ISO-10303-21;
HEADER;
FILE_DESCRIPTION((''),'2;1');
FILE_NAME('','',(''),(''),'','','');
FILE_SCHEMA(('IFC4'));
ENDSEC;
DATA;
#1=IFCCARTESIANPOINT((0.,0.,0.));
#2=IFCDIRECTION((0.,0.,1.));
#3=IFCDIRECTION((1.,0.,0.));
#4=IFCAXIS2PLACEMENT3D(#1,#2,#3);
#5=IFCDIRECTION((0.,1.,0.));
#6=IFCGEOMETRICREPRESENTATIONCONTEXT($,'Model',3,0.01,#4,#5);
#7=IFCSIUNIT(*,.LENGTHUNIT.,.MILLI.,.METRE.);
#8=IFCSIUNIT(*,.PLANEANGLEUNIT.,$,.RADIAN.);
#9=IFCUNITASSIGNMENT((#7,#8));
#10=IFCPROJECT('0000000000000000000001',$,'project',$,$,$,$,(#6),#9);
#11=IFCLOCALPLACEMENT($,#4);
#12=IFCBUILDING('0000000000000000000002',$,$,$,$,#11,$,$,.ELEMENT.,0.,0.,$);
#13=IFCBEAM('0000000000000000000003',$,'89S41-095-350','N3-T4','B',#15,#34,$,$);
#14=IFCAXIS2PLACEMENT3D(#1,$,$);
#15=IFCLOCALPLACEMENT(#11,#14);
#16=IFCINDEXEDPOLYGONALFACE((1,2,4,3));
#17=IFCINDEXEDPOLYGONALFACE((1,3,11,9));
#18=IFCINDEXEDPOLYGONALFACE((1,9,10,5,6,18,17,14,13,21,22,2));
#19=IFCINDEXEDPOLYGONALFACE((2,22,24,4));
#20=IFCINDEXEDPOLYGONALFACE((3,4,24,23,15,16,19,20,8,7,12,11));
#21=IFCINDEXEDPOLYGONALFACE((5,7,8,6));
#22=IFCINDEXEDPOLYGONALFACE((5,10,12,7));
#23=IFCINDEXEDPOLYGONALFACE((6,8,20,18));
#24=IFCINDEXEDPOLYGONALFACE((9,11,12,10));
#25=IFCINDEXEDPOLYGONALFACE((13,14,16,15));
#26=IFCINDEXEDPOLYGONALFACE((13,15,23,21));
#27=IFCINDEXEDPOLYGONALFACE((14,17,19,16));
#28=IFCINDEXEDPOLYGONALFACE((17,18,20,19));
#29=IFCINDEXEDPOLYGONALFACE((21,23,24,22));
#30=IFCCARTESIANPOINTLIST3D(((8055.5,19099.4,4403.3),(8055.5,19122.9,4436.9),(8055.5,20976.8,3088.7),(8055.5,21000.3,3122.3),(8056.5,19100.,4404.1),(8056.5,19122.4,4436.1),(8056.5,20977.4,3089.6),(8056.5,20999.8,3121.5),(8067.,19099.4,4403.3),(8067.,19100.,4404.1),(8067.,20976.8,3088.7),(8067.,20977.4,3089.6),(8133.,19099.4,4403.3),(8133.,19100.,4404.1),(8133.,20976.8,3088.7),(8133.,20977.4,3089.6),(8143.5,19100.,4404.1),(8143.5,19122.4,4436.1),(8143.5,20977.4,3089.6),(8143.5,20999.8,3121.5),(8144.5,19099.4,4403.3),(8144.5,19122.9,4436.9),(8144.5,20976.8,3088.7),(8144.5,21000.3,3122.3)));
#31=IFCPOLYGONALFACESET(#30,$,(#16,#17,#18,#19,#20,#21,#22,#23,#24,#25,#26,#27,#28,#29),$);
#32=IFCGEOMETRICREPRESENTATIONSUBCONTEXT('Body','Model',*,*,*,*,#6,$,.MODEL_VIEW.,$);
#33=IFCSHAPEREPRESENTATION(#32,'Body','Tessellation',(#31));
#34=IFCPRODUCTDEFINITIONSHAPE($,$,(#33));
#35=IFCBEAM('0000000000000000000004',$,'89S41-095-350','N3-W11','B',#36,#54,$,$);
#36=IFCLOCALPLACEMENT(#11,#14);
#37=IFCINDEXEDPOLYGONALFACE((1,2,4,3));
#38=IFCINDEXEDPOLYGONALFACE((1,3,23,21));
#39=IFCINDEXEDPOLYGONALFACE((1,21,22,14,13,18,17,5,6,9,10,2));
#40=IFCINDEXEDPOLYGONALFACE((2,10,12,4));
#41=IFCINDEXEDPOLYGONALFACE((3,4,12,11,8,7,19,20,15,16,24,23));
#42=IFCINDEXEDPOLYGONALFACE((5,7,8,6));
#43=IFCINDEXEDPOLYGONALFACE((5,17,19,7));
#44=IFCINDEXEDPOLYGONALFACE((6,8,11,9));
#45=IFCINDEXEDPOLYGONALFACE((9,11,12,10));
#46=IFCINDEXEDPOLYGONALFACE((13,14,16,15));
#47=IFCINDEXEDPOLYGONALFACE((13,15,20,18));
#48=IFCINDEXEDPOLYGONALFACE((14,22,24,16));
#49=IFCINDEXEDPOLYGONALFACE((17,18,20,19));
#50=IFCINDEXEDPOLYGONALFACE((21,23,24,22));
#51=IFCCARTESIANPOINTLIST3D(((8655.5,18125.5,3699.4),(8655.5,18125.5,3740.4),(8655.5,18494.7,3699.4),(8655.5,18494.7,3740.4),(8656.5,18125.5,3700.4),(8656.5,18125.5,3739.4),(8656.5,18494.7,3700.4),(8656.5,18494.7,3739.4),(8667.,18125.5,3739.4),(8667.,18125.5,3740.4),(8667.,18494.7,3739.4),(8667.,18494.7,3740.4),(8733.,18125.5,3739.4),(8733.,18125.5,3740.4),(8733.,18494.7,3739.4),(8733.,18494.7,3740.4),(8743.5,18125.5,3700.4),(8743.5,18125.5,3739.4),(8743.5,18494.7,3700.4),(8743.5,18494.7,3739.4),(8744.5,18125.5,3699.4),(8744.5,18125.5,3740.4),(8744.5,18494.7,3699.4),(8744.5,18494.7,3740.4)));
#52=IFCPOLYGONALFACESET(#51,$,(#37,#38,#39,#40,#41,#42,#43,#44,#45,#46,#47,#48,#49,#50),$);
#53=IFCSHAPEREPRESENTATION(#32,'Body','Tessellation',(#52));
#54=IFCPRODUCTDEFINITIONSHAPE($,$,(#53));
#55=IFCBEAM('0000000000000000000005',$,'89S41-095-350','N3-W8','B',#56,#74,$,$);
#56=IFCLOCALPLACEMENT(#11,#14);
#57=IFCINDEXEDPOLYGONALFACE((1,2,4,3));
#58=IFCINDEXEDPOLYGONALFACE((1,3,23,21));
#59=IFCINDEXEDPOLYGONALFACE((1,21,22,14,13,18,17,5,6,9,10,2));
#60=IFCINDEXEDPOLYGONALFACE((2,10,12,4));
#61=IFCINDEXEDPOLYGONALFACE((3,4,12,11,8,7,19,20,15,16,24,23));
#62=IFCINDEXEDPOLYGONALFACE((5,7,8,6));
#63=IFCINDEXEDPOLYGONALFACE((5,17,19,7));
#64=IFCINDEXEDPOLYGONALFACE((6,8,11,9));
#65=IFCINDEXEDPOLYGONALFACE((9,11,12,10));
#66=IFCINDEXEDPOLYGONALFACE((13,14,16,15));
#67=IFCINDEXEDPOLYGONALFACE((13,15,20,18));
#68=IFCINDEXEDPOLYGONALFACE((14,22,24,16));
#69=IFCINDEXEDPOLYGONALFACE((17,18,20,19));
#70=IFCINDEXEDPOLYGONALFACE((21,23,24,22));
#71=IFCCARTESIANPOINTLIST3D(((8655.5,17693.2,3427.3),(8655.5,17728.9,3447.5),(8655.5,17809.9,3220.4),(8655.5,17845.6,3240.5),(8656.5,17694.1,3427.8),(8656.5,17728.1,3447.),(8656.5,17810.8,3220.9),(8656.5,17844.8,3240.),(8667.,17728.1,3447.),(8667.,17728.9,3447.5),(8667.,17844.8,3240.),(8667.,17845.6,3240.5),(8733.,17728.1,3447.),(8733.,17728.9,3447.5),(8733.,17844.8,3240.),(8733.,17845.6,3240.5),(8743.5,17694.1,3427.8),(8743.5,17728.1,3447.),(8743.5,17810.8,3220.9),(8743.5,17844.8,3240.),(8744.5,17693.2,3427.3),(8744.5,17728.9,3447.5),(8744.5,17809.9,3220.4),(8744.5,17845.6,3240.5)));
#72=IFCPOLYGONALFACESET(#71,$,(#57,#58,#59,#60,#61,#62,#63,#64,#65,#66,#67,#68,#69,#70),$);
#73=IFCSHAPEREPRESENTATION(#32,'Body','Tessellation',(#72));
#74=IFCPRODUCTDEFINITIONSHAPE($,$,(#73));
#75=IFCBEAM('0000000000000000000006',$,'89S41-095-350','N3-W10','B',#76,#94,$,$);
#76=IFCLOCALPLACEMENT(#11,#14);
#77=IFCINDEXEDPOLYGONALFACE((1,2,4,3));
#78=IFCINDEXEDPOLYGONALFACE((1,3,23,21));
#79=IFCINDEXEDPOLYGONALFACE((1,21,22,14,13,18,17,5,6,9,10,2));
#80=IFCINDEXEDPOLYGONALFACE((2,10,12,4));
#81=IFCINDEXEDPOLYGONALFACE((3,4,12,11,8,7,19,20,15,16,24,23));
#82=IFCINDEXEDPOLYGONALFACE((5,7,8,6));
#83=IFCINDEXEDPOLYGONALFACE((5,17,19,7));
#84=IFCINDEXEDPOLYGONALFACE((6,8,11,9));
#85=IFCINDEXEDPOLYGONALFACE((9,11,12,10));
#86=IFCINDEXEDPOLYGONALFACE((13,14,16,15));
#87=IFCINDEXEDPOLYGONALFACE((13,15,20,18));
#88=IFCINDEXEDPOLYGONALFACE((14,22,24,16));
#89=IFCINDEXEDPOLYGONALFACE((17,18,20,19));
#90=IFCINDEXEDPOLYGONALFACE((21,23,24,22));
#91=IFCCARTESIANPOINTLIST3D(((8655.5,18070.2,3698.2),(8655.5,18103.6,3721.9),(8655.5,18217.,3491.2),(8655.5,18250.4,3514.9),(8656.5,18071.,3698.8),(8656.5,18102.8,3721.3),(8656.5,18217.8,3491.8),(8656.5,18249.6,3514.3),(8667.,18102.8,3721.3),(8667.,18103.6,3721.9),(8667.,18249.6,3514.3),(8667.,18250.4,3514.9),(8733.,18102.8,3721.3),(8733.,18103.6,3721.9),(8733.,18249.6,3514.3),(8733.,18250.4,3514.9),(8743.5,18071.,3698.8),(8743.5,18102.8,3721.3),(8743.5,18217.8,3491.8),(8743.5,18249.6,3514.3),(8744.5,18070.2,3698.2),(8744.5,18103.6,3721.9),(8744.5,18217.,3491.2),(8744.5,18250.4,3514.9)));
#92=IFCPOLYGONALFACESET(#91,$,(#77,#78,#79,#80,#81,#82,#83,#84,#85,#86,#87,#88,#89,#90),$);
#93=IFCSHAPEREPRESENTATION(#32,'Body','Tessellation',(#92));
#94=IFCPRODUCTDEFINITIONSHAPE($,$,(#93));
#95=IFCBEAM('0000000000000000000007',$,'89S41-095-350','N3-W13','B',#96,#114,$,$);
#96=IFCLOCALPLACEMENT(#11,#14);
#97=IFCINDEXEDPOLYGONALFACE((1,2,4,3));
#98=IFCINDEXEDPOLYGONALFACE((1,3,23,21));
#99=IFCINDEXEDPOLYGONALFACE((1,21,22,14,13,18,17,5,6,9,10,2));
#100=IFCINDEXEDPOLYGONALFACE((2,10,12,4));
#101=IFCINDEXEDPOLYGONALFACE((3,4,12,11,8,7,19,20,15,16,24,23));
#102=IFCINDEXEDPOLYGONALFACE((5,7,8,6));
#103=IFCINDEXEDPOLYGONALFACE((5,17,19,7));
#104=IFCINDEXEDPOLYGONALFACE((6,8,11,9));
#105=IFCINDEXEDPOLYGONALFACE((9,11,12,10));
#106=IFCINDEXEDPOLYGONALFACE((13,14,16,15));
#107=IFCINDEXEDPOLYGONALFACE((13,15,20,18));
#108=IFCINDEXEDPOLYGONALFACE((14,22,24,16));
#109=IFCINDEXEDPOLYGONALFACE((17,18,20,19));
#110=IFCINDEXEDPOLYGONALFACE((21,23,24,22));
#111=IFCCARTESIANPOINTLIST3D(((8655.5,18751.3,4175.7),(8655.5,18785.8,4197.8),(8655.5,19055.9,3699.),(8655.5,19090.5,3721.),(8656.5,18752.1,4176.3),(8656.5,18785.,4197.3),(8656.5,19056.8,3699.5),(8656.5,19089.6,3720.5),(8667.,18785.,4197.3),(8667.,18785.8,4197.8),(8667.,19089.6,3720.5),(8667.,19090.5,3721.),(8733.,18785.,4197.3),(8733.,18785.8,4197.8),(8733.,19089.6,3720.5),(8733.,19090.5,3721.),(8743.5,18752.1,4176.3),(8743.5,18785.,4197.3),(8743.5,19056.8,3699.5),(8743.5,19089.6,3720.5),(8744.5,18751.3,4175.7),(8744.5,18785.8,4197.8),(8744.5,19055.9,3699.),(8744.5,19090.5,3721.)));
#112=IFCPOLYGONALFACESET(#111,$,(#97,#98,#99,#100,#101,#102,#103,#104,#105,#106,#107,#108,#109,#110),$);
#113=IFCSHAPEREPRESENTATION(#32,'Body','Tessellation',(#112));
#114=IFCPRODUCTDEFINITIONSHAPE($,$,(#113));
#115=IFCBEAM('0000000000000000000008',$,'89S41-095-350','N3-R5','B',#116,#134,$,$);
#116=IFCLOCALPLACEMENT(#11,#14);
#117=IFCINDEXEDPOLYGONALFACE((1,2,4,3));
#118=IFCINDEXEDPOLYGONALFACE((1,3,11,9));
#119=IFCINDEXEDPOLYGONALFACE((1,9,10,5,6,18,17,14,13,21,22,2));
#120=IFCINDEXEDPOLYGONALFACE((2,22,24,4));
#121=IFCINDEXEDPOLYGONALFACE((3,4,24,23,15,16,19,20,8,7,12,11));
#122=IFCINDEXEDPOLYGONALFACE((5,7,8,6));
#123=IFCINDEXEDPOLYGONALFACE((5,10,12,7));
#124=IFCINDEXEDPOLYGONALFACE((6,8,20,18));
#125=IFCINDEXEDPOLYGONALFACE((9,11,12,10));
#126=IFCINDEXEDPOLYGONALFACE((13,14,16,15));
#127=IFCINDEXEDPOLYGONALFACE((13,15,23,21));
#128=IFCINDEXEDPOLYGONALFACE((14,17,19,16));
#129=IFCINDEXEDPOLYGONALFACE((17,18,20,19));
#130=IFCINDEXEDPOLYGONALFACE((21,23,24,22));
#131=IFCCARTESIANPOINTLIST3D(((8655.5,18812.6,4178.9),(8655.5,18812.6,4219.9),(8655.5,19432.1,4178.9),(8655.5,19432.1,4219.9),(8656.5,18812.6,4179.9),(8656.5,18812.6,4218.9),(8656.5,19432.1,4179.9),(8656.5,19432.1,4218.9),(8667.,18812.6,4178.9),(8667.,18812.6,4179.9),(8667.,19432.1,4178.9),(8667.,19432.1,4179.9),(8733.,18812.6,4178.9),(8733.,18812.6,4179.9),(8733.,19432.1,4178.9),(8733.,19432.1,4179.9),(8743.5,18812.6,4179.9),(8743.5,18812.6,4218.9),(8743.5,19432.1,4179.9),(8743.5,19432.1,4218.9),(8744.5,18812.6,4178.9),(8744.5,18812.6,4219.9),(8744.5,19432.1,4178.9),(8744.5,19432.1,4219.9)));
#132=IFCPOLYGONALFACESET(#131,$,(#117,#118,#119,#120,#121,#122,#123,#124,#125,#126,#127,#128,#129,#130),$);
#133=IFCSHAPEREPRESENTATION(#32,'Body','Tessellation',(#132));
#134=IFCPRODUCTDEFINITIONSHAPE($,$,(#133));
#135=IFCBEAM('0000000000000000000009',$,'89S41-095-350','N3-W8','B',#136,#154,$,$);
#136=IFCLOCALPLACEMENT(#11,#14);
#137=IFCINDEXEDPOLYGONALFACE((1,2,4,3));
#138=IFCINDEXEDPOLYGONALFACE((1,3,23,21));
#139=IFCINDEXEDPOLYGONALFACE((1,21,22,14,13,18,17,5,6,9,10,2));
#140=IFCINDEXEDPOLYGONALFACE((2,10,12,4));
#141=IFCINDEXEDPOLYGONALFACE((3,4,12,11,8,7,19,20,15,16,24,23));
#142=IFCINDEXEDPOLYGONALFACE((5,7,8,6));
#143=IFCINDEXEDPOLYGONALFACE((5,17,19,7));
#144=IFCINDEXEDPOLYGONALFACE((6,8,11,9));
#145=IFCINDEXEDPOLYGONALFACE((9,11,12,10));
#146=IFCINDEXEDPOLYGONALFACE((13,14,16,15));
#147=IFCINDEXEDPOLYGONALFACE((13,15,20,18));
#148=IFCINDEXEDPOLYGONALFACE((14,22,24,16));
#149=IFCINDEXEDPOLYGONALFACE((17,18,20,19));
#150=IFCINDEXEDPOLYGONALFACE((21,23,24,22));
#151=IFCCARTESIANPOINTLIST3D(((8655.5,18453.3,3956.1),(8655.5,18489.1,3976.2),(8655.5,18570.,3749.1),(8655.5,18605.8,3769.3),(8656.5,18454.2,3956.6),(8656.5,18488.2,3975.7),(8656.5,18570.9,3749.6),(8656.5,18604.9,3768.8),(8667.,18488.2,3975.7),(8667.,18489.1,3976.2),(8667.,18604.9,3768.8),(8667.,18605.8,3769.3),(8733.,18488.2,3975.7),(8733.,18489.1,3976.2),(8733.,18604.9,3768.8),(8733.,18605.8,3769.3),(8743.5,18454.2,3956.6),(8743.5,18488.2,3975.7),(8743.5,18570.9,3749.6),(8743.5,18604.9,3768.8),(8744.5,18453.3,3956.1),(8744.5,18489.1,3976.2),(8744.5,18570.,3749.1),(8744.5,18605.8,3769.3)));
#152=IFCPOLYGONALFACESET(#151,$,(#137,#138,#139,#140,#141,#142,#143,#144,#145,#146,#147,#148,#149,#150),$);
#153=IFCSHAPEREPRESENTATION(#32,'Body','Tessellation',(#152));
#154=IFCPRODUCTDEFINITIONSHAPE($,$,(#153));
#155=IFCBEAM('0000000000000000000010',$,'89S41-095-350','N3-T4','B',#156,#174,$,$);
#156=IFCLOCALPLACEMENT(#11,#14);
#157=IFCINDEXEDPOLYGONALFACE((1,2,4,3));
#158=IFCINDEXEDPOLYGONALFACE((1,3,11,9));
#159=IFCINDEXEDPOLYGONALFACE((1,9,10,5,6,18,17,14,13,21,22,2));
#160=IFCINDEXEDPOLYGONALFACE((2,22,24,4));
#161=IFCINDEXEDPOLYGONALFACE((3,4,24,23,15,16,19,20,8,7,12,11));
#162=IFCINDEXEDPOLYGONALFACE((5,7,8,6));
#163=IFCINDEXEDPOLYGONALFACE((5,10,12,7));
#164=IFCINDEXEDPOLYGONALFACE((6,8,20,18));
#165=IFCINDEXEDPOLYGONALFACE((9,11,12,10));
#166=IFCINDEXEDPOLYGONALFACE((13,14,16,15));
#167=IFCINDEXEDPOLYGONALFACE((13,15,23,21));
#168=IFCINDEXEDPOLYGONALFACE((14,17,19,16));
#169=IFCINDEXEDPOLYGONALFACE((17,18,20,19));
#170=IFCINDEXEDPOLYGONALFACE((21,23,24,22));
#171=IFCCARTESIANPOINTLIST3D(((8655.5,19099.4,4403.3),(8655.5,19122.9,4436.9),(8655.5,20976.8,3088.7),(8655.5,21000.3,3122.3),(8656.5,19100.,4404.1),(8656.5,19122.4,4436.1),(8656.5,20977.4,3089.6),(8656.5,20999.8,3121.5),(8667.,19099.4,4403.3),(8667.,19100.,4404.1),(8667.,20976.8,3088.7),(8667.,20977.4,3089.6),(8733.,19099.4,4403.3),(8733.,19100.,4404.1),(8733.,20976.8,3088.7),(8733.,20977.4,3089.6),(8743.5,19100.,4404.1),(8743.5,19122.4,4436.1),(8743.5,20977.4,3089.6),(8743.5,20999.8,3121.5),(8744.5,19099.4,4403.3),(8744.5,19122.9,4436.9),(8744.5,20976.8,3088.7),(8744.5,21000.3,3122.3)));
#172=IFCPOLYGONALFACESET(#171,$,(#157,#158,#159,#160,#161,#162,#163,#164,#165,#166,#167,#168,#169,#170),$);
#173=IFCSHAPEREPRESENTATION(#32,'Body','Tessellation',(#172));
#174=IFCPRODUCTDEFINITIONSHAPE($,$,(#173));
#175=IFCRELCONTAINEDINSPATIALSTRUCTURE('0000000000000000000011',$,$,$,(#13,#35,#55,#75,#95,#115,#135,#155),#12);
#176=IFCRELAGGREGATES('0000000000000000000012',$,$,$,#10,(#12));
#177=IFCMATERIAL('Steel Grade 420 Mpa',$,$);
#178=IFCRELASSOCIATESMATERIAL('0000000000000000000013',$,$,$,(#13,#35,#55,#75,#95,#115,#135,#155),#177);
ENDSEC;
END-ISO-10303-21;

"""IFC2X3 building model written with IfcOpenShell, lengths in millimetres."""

from ifc_helpers import new_model, si_unit, direction, frame, origin, origin_with_axes, origin_2d_with_axis, place, context, subcontext, project, spatial, c_section, extrude, source, transform, mapped, material, element, save


model = new_model("IFC2X3")

# Units and contexts
model_context = context("Model", 3, precision=0.01, world=origin_with_axes(), true_north=direction((0.0, 1.0, 0.0)))
body_context = subcontext(model_context, "Body", "Model", "MODEL_VIEW")
ifc_project = project(units=[si_unit("LENGTHUNIT", "METRE", prefix="MILLI"), si_unit("PLANEANGLEUNIT", "RADIAN")], contexts=[model_context])

# Building
building_placement = place(None, origin_with_axes())
building = spatial("IfcBuilding", under=ifc_project, at=building_placement, CompositionType="ELEMENT", ElevationOfRefHeight=0.0, ElevationOfTerrain=0.0)

# Shared definitions
ifc_material = material(Name="Steel Grade 420 Mpa")

# Beams
shared_shape_1 = source(origin(), body_context, "Body", "SweptSolid", [
    extrude(c_section(Depth=89.0, Width=41.0, WallThickness=1.0, Girth=11.5, at=origin_2d_with_axis()), origin_with_axes(), (0.0, 0.0, 1.0), 2291.9),
])
beam_1_placement = place(None, frame((8100.0, 19111.2, 4420.1), z_axis=(0.0, 0.819152, -0.573576), x_axis=(0.0, -0.573576, -0.819152)))
element("IfcBeam", 1, at=beam_1_placement, inside=building, material=ifc_material, Name="89S41-095-350", Description="N3-T4", ObjectType="B", context=body_context, shape_type="MappedRepresentation", body=[
    mapped(shared_shape_1, transform((0.0, 0.0, 0.0), scale=1.0)),
])
shared_shape_2 = source(origin(), body_context, "Body", "SweptSolid", [
    extrude(c_section(Depth=89.0, Width=41.0, WallThickness=1.0, Girth=11.5, at=origin_2d_with_axis()), origin_with_axes(), (0.0, 0.0, 1.0), 369.2),
])
beam_2_placement = place(None, frame((8700.0, 18494.7, 3719.9), z_axis=(0.0, -1.0, 0.0), x_axis=(0.0, 0.0, 1.0)))
element("IfcBeam", 2, at=beam_2_placement, inside=building, material=ifc_material, Name="89S41-095-350", Description="N3-W11", ObjectType="B", context=body_context, shape_type="MappedRepresentation", body=[
    mapped(shared_shape_2, transform((0.0, 0.0, 0.0), scale=1.0)),
])
shared_shape_3 = source(origin(), body_context, "Body", "SweptSolid", [
    extrude(c_section(Depth=89.0, Width=41.0, WallThickness=1.0, Girth=11.5, at=origin_2d_with_axis()), origin_with_axes(), (0.0, 0.0, 1.0), 237.6),
])
beam_3_placement = place(None, frame((8700.0, 17827.8, 3230.5), z_axis=(0.0, -0.491169, 0.871064), x_axis=(0.0, 0.871064, 0.491169)))
element("IfcBeam", 3, at=beam_3_placement, inside=building, material=ifc_material, Name="89S41-095-350", Description="N3-W8", ObjectType="B", context=body_context, shape_type="MappedRepresentation", body=[
    mapped(shared_shape_3, transform((0.0, 0.0, 0.0), scale=1.0)),
])
shared_shape_4 = source(origin(), body_context, "Body", "SweptSolid", [
    extrude(c_section(Depth=89.0, Width=41.0, WallThickness=1.0, Girth=11.5, at=origin_2d_with_axis()), origin_with_axes(), (0.0, 0.0, 1.0), 253.8),
])
beam_4_placement = place(None, frame((8700.0, 18233.7, 3503.0), z_axis=(0.0, -0.578484, 0.815694), x_axis=(0.0, 0.815694, 0.578484)))
element("IfcBeam", 4, at=beam_4_placement, inside=building, material=ifc_material, Name="89S41-095-350", Description="N3-W10", ObjectType="B", context=body_context, shape_type="MappedRepresentation", body=[
    mapped(shared_shape_4, transform((0.0, 0.0, 0.0), scale=1.0)),
])
shared_shape_5 = source(origin(), body_context, "Body", "SweptSolid", [
    extrude(c_section(Depth=89.0, Width=41.0, WallThickness=1.0, Girth=11.5, at=origin_2d_with_axis()), origin_with_axes(), (0.0, 0.0, 1.0), 565.8),
])
beam_5_placement = place(None, frame((8700.0, 19073.2, 3710.0), z_axis=(0.0, -0.538498, 0.842627), x_axis=(0.0, 0.842627, 0.538498)))
element("IfcBeam", 5, at=beam_5_placement, inside=building, material=ifc_material, Name="89S41-095-350", Description="N3-W13", ObjectType="B", context=body_context, shape_type="MappedRepresentation", body=[
    mapped(shared_shape_5, transform((0.0, 0.0, 0.0), scale=1.0)),
])
shared_shape_6 = source(origin(), body_context, "Body", "SweptSolid", [
    extrude(c_section(Depth=89.0, Width=41.0, WallThickness=1.0, Girth=11.5, at=origin_2d_with_axis()), origin_with_axes(), (0.0, 0.0, 1.0), 619.5),
])
beam_6_placement = place(None, frame((8700.0, 18812.6, 4199.4), z_axis=(0.0, 1.0, 0.0), x_axis=(0.0, 0.0, -1.0)))
element("IfcBeam", 6, at=beam_6_placement, inside=building, material=ifc_material, Name="89S41-095-350", Description="N3-R5", ObjectType="B", context=body_context, shape_type="MappedRepresentation", body=[
    mapped(shared_shape_6, transform((0.0, 0.0, 0.0), scale=1.0)),
])
shared_shape_7 = source(origin(), body_context, "Body", "SweptSolid", [
    extrude(c_section(Depth=89.0, Width=41.0, WallThickness=1.0, Girth=11.5, at=origin_2d_with_axis()), origin_with_axes(), (0.0, 0.0, 1.0), 237.6),
])
beam_7_placement = place(None, frame((8700.0, 18587.9, 3759.2), z_axis=(0.0, -0.491169, 0.871064), x_axis=(0.0, 0.871064, 0.491169)))
element("IfcBeam", 7, at=beam_7_placement, inside=building, material=ifc_material, Name="89S41-095-350", Description="N3-W8", ObjectType="B", context=body_context, shape_type="MappedRepresentation", body=[
    mapped(shared_shape_7, transform((0.0, 0.0, 0.0), scale=1.0)),
])
shared_shape_8 = source(origin(), body_context, "Body", "SweptSolid", [
    extrude(c_section(Depth=89.0, Width=41.0, WallThickness=1.0, Girth=11.5, at=origin_2d_with_axis()), origin_with_axes(), (0.0, 0.0, 1.0), 2291.9),
])
beam_8_placement = place(None, frame((8700.0, 19111.2, 4420.1), z_axis=(0.0, 0.819152, -0.573576), x_axis=(0.0, -0.573576, -0.819152)))
element("IfcBeam", 8, at=beam_8_placement, inside=building, material=ifc_material, Name="89S41-095-350", Description="N3-T4", ObjectType="B", context=body_context, shape_type="MappedRepresentation", body=[
    mapped(shared_shape_8, transform((0.0, 0.0, 0.0), scale=1.0)),
])

save(model, "model.ifc")
